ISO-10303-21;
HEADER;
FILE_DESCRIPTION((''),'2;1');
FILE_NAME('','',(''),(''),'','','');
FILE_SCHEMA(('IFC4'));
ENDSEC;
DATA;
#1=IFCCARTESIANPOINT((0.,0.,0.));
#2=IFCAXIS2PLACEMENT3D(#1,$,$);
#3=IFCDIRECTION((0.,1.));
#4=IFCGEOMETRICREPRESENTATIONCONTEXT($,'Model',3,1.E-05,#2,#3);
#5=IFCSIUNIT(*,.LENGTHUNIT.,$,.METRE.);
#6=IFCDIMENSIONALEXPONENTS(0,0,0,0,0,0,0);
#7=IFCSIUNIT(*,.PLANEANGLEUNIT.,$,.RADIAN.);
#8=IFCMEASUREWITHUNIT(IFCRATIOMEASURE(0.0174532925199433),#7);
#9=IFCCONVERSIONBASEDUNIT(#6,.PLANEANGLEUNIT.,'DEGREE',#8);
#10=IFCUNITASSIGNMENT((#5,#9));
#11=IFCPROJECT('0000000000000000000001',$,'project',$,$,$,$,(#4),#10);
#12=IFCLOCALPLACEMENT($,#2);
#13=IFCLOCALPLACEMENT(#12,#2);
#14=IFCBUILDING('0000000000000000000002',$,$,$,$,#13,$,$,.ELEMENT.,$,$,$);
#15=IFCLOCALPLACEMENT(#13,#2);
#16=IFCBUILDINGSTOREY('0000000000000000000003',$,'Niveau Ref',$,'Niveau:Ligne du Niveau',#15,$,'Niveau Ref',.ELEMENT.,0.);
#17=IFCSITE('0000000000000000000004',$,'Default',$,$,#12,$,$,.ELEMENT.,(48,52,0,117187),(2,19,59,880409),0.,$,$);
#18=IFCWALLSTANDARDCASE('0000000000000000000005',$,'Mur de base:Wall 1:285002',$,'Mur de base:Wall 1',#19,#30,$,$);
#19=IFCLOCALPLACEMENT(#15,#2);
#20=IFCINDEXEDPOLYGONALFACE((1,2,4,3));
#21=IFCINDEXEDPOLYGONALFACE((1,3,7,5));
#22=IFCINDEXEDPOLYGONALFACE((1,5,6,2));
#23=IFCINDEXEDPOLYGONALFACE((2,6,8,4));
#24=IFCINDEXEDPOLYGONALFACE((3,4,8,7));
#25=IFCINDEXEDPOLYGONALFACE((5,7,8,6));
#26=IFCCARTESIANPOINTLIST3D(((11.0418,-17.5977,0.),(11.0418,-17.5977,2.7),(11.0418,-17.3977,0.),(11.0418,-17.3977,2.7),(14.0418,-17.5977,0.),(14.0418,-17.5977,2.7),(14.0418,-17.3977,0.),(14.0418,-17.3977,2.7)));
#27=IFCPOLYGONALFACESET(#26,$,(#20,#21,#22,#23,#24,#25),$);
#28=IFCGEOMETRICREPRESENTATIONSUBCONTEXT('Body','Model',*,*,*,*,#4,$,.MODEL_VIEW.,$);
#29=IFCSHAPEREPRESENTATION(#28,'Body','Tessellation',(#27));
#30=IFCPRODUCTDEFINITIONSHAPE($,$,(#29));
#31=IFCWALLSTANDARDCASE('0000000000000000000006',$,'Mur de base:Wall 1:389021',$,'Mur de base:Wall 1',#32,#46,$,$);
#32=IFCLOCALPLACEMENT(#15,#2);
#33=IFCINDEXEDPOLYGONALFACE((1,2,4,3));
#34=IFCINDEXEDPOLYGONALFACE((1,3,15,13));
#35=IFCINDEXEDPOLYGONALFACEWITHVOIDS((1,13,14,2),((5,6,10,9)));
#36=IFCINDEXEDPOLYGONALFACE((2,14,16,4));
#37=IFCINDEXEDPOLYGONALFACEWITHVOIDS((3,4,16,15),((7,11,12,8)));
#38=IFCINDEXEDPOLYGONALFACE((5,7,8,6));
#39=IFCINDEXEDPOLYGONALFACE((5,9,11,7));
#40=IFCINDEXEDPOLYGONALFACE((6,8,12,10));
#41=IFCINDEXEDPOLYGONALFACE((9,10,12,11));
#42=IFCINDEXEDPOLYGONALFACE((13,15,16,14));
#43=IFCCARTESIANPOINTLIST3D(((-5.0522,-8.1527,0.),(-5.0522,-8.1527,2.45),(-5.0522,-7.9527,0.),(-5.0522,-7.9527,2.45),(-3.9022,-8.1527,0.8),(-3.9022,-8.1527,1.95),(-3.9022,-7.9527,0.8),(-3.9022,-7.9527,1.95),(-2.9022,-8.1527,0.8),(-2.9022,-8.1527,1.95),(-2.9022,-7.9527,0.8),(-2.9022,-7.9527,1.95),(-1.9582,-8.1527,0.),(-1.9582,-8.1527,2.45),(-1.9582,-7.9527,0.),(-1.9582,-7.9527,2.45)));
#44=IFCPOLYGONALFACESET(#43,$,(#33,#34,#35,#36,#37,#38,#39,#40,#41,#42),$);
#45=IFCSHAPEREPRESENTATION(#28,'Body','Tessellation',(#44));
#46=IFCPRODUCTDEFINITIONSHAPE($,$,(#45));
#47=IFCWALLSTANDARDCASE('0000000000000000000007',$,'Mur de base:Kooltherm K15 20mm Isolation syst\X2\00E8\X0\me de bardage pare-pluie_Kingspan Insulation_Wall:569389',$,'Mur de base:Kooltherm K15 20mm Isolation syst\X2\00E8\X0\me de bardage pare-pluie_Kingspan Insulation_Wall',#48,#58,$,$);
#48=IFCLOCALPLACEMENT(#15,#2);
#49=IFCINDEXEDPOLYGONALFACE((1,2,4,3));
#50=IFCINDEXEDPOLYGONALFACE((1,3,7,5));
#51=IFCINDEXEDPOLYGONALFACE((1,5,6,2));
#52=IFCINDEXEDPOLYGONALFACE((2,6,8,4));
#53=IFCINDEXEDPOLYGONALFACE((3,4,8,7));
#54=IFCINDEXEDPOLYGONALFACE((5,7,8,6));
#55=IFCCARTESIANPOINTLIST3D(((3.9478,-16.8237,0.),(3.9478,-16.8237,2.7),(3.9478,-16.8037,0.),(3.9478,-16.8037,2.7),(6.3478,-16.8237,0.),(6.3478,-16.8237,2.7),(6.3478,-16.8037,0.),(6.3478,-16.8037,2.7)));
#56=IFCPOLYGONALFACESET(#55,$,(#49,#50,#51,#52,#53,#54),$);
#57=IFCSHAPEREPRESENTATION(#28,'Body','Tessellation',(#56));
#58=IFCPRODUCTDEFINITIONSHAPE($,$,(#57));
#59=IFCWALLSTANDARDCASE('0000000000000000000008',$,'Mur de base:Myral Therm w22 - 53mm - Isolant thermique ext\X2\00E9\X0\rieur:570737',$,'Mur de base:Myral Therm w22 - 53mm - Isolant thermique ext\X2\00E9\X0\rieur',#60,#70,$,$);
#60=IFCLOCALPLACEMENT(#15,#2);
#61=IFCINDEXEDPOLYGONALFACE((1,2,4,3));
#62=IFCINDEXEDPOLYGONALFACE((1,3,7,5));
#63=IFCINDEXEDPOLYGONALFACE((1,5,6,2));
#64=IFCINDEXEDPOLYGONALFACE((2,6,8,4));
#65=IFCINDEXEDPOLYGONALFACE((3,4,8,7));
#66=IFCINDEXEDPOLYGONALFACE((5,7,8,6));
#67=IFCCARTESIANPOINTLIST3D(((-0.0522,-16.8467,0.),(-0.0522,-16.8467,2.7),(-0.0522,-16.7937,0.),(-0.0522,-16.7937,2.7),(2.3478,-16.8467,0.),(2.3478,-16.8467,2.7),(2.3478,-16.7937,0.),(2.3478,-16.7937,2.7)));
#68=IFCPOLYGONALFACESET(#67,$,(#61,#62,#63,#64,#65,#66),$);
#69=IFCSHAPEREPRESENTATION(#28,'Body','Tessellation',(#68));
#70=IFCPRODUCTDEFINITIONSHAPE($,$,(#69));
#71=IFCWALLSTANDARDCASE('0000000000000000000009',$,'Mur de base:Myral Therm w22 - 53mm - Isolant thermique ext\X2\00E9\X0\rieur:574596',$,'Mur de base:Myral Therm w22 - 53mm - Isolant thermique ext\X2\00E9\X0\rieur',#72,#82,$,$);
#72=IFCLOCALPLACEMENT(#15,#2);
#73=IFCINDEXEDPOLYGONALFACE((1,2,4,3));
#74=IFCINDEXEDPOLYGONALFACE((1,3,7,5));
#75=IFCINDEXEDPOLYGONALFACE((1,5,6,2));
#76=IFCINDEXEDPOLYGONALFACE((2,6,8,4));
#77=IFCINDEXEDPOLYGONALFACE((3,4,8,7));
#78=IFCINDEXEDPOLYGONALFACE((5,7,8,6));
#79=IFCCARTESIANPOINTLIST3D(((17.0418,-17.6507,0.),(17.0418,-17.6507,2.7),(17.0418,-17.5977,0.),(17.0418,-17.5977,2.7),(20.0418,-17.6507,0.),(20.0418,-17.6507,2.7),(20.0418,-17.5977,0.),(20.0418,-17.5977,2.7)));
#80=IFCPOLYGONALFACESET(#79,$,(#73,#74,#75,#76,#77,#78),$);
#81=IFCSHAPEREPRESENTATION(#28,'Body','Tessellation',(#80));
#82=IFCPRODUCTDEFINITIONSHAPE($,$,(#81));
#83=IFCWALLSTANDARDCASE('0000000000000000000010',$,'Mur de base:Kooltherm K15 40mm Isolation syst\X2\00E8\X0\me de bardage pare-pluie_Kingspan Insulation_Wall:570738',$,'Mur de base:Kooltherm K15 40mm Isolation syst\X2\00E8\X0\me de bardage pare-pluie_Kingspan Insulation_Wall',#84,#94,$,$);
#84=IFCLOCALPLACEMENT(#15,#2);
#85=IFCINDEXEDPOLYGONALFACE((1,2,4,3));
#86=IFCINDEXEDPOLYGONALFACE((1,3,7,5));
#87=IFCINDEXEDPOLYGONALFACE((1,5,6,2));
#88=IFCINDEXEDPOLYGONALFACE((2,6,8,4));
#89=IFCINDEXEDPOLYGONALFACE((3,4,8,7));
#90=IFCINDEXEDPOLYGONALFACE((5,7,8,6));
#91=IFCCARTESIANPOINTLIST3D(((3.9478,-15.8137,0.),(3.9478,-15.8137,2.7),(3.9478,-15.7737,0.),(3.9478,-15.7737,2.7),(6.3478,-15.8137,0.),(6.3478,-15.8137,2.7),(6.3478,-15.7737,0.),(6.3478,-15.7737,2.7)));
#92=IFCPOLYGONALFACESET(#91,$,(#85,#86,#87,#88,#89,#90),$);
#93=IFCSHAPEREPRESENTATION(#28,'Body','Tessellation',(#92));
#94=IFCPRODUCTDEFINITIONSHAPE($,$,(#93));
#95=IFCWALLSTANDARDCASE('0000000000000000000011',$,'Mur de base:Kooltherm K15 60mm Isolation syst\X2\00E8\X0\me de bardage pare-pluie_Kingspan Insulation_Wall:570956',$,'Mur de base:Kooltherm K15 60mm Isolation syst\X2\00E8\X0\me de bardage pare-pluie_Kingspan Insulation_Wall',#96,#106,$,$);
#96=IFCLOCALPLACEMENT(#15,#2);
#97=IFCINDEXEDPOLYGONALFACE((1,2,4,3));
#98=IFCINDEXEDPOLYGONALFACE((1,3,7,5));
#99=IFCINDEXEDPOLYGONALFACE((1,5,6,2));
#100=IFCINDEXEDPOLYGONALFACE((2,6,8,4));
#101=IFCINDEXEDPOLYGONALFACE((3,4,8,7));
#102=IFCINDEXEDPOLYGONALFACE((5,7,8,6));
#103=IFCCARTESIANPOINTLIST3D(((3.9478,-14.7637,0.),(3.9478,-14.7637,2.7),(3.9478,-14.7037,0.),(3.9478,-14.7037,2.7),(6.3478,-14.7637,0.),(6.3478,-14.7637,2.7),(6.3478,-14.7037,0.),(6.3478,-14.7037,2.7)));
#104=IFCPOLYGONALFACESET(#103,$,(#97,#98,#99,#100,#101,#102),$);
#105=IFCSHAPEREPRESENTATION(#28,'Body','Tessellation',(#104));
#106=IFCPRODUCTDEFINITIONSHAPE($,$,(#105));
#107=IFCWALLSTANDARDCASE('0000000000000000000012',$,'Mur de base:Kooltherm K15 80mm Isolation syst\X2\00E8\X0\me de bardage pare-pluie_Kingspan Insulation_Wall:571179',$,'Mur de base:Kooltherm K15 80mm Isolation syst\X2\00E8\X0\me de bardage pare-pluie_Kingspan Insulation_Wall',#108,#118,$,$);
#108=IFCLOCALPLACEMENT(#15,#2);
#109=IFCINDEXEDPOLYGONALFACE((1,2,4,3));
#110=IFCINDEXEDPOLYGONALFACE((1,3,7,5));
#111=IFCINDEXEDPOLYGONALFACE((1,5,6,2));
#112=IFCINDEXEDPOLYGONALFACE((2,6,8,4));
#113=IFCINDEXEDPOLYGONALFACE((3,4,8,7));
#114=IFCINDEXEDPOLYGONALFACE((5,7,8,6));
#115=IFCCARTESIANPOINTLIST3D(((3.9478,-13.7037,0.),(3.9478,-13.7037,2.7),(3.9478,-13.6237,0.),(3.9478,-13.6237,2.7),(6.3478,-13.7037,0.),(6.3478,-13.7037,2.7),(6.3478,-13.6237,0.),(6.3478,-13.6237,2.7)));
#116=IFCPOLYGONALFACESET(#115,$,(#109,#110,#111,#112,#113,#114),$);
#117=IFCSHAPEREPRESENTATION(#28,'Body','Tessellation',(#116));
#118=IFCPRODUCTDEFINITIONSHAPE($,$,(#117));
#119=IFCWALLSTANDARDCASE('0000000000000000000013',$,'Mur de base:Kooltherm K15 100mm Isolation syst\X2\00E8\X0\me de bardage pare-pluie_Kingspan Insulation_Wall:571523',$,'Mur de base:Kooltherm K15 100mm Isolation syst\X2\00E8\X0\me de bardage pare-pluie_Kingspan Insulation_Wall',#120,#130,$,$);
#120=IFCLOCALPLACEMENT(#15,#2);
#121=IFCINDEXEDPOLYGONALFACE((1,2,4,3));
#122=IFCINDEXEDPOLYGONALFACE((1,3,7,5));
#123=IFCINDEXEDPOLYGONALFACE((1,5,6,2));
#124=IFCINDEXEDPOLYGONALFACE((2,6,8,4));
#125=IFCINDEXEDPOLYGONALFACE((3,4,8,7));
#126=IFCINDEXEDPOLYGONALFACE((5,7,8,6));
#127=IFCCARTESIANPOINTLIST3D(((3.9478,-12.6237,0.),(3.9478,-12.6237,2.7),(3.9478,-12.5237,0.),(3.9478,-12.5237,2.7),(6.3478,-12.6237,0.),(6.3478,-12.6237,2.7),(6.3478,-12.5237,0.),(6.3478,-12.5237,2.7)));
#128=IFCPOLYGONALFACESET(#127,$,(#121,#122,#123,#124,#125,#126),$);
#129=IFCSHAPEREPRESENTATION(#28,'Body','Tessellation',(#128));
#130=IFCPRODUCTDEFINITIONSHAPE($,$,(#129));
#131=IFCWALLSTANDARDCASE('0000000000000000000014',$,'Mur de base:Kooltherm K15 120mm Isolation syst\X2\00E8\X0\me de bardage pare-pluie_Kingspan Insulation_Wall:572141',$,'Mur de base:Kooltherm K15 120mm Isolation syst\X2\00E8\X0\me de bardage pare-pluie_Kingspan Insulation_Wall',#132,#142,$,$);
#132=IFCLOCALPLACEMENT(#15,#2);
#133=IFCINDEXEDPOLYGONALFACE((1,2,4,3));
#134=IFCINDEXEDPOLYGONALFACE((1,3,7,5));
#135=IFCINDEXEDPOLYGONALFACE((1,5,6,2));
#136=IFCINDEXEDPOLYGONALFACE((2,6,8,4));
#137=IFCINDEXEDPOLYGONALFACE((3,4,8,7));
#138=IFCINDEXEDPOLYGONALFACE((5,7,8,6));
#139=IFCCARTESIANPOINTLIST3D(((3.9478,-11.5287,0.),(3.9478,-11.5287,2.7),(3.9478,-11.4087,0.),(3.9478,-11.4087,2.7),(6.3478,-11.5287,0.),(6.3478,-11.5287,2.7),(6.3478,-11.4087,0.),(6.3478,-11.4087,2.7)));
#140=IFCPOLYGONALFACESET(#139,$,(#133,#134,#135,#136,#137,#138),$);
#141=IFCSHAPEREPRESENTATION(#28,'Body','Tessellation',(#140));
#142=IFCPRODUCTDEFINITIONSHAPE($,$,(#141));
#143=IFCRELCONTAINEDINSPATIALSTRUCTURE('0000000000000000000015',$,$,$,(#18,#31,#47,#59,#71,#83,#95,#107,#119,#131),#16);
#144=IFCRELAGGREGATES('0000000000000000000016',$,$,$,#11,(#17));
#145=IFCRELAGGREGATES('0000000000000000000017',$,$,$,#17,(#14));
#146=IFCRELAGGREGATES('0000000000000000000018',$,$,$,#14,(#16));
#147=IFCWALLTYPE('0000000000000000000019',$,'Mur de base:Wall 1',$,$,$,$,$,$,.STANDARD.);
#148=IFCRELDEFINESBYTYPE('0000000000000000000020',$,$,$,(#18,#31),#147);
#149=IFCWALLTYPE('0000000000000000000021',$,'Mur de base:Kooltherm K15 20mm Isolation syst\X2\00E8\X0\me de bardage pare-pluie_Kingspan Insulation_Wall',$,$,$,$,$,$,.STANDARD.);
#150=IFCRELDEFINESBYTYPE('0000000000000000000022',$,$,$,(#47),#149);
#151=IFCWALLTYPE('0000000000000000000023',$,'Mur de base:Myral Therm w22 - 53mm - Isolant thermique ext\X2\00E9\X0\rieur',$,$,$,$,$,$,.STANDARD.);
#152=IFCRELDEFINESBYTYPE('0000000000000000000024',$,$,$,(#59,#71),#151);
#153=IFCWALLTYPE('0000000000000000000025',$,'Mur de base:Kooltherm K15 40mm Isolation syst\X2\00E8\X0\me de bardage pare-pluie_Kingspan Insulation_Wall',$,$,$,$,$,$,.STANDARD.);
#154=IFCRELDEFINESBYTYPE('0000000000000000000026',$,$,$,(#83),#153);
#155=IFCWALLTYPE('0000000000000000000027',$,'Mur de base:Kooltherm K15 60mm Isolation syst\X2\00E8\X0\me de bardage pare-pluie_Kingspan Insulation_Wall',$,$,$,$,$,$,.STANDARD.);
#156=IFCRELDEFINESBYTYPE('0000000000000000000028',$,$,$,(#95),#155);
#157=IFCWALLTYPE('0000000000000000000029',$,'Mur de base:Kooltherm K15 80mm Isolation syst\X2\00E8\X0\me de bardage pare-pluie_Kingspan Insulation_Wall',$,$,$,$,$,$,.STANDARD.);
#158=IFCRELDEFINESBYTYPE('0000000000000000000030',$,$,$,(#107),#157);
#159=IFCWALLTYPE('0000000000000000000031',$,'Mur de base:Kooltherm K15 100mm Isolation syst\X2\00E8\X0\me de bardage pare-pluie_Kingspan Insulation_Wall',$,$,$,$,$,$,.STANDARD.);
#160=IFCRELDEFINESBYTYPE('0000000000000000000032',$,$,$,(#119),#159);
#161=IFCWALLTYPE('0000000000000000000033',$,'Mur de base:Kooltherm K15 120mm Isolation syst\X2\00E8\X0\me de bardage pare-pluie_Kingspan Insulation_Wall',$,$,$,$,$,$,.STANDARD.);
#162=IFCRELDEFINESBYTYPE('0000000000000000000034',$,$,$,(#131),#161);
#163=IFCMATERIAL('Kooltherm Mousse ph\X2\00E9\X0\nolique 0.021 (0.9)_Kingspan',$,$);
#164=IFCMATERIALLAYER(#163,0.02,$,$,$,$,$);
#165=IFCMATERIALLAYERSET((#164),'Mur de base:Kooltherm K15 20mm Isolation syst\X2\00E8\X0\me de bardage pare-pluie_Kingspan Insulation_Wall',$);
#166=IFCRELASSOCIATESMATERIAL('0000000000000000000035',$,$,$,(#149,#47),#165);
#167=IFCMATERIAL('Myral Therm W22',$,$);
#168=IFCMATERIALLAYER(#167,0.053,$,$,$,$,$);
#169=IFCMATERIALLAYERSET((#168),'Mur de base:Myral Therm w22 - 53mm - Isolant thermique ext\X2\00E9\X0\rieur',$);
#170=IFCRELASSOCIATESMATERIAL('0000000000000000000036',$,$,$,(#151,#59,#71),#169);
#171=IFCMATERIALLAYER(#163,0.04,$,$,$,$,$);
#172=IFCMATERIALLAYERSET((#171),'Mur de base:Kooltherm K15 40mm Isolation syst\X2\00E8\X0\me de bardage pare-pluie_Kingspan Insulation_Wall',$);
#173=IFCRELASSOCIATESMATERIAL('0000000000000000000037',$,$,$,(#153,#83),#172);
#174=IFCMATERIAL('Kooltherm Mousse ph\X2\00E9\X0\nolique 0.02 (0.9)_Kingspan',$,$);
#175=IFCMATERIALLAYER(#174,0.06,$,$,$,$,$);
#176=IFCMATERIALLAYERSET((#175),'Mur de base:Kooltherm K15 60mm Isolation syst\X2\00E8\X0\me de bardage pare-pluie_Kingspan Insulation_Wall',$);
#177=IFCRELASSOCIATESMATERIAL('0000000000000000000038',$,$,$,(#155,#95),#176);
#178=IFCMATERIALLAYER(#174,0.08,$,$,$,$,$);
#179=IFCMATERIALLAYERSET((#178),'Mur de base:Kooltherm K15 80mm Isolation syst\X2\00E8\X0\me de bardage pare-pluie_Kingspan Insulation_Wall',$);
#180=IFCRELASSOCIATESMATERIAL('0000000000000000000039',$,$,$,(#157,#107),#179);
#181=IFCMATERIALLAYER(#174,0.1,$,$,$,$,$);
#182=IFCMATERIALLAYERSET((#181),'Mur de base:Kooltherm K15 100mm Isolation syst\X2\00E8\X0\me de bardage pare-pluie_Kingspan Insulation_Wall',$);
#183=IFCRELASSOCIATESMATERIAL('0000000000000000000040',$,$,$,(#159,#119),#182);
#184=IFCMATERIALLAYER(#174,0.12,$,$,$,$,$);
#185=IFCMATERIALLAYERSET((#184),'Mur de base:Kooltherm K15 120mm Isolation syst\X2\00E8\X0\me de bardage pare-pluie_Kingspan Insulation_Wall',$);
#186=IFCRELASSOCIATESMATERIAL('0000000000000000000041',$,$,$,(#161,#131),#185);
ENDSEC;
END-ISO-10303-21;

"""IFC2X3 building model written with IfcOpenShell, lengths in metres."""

from ifc_helpers import new_model, entity, si_unit, converted_unit, direction, frame, frame_2d, origin, place, context, subcontext, project, spatial, rectangle, extrude, material, layer, layer_set, layer_usage, type_object, element, save


model = new_model("IFC2X3")

# Units and contexts
model_context = context("Model", 3, precision=1e-05, world=origin(), true_north=direction((0.0, 1.0)))
body_context = subcontext(model_context, "Body", "Model", "MODEL_VIEW")
ifc_project = project(units=[si_unit("LENGTHUNIT", "METRE"), converted_unit("PLANEANGLEUNIT", "DEGREE", entity("IfcRatioMeasure", 0.0174532925199433), si_unit("PLANEANGLEUNIT", "RADIAN"), dimensions=[0, 0, 0, 0, 0, 0, 0])], contexts=[model_context])

# Site, building, storey
site_placement = place(None, origin())
site = spatial("IfcSite", under=ifc_project, at=site_placement, Name="Default", CompositionType="ELEMENT", RefLatitude=(48, 52, 0, 117187), RefLongitude=(2, 19, 59, 880409), RefElevation=0.0)
building_placement = place(site_placement, origin())
building = spatial("IfcBuilding", under=site, at=building_placement, CompositionType="ELEMENT")
storey_placement = place(building_placement, origin())
storey = spatial("IfcBuildingStorey", under=building, at=storey_placement, Name="Niveau Ref", ObjectType="Niveau:Ligne du Niveau", LongName="Niveau Ref", CompositionType="ELEMENT", Elevation=0.0)

# Wall
wall_type_1 = type_object("IfcWallType", Name="Mur de base:Wall 1", PredefinedType="STANDARD")
for number, where, name in (
    (1, (11.0418, -17.4977, 0.0), "Mur de base:Wall 1:285002"),
):
    element("IfcWallStandardCase", number, at=place(storey_placement, frame(where)), inside=storey, type_object=wall_type_1, Name=name, ObjectType="Mur de base:Wall 1", context=body_context, shape_type="SweptSolid", body=[
        extrude(rectangle(XDim=3.0, YDim=0.2, at=frame_2d((1.5, 0.0), x_axis=(-1.0, 0.0))), origin(), (0.0, 0.0, 1.0), 2.7),
    ])

# Wall, opening
wall_1_placement = place(storey_placement, frame((-1.9582, -8.0527, 0.0), z_axis=(0.0, 0.0, 1.0), x_axis=(-1.0, 0.0, 0.0)))
wall_1 = element("IfcWallStandardCase", 2, at=wall_1_placement, inside=storey, type_object=wall_type_1, Name="Mur de base:Wall 1:389021", ObjectType="Mur de base:Wall 1", context=body_context, shape_type="SweptSolid", body=[
    extrude(rectangle(XDim=3.094, YDim=0.2, at=frame_2d((1.547, 0.0), x_axis=(-1.0, 0.0))), origin(), (0.0, 0.0, 1.0), 2.45),
])
opening_placement = place(wall_1_placement, frame((0.944, -0.1, 0.8)))
element("IfcOpeningElement", 3, at=opening_placement, cuts=wall_1, ObjectType="Opening", context=body_context, shape_type="SweptSolid", body=[
    extrude(rectangle(XDim=1.15, YDim=1.0, at=frame_2d((0.575, 0.5), x_axis=(1.0, 0.0))), frame((0.0, 0.0, 0.0), z_axis=(0.0, 1.0, 0.0), x_axis=(0.0, 0.0, 1.0)), (0.0, 0.0, 1.0), 0.2),
])

# Walls
ifc_material_1 = material(Name="Kooltherm Mousse phénolique 0.021 (0.9)_Kingspan")
ifc_layer_1 = layer(ifc_material_1, 0.02)
ifc_layer_set_1 = layer_set([ifc_layer_1], Name="Mur de base:Kooltherm K15 20mm Isolation système de bardage pare-pluie_Kingspan Insulation_Wall")
ifc_layer_usage_1 = layer_usage(ifc_layer_set_1, "AXIS2", "NEGATIVE", 0.01)
wall_type_2 = type_object("IfcWallType", Name="Mur de base:Kooltherm K15 20mm Isolation système de bardage pare-pluie_Kingspan Insulation_Wall", PredefinedType="STANDARD", material=ifc_layer_set_1)
wall_2_placement = place(storey_placement, frame((3.9478, -16.8137, 0.0)))
element("IfcWallStandardCase", 4, at=wall_2_placement, inside=storey, type_object=wall_type_2, material=ifc_layer_usage_1, Name="Mur de base:Kooltherm K15 20mm Isolation système de bardage pare-pluie_Kingspan Insulation_Wall:569389", ObjectType="Mur de base:Kooltherm K15 20mm Isolation système de bardage pare-pluie_Kingspan Insulation_Wall", context=body_context, shape_type="SweptSolid", body=[
    extrude(rectangle(XDim=2.4, YDim=0.02, at=frame_2d((1.2, 0.0), x_axis=(-1.0, 0.0))), origin(), (0.0, 0.0, 1.0), 2.7),
])
ifc_material_2 = material(Name="Myral Therm W22")
ifc_layer_2 = layer(ifc_material_2, 0.053)
ifc_layer_set_2 = layer_set([ifc_layer_2], Name="Mur de base:Myral Therm w22 - 53mm - Isolant thermique extérieur")
ifc_layer_usage_2 = layer_usage(ifc_layer_set_2, "AXIS2", "NEGATIVE", 0.0265)
wall_type_3 = type_object("IfcWallType", Name="Mur de base:Myral Therm w22 - 53mm - Isolant thermique extérieur", PredefinedType="STANDARD", material=ifc_layer_set_2)
wall_3_placement = place(storey_placement, frame((-0.0522, -16.8202, 0.0)))
element("IfcWallStandardCase", 5, at=wall_3_placement, inside=storey, type_object=wall_type_3, material=ifc_layer_usage_2, Name="Mur de base:Myral Therm w22 - 53mm - Isolant thermique extérieur:570737", ObjectType="Mur de base:Myral Therm w22 - 53mm - Isolant thermique extérieur", context=body_context, shape_type="SweptSolid", body=[
    extrude(rectangle(XDim=2.4, YDim=0.053, at=frame_2d((1.2, 0.0), x_axis=(-1.0, 0.0))), origin(), (0.0, 0.0, 1.0), 2.7),
])
ifc_layer_usage_3 = layer_usage(ifc_layer_set_2, "AXIS2", "NEGATIVE", 0.0265)
wall_4_placement = place(storey_placement, frame((17.0418, -17.6242, 0.0)))
element("IfcWallStandardCase", 6, at=wall_4_placement, inside=storey, type_object=wall_type_3, material=ifc_layer_usage_3, Name="Mur de base:Myral Therm w22 - 53mm - Isolant thermique extérieur:574596", ObjectType="Mur de base:Myral Therm w22 - 53mm - Isolant thermique extérieur", context=body_context, shape_type="SweptSolid", body=[
    extrude(rectangle(XDim=3.0, YDim=0.053, at=frame_2d((1.5, 0.0), x_axis=(-1.0, 0.0))), origin(), (0.0, 0.0, 1.0), 2.7),
])
ifc_layer_3 = layer(ifc_material_1, 0.04)
ifc_layer_set_3 = layer_set([ifc_layer_3], Name="Mur de base:Kooltherm K15 40mm Isolation système de bardage pare-pluie_Kingspan Insulation_Wall")
ifc_layer_usage_4 = layer_usage(ifc_layer_set_3, "AXIS2", "NEGATIVE", 0.02)
wall_type_4 = type_object("IfcWallType", Name="Mur de base:Kooltherm K15 40mm Isolation système de bardage pare-pluie_Kingspan Insulation_Wall", PredefinedType="STANDARD", material=ifc_layer_set_3)
wall_5_placement = place(storey_placement, frame((3.9478, -15.7937, 0.0)))
element("IfcWallStandardCase", 7, at=wall_5_placement, inside=storey, type_object=wall_type_4, material=ifc_layer_usage_4, Name="Mur de base:Kooltherm K15 40mm Isolation système de bardage pare-pluie_Kingspan Insulation_Wall:570738", ObjectType="Mur de base:Kooltherm K15 40mm Isolation système de bardage pare-pluie_Kingspan Insulation_Wall", context=body_context, shape_type="SweptSolid", body=[
    extrude(rectangle(XDim=2.4, YDim=0.04, at=frame_2d((1.2, 0.0), x_axis=(-1.0, 0.0))), origin(), (0.0, 0.0, 1.0), 2.7),
])
ifc_material_3 = material(Name="Kooltherm Mousse phénolique 0.02 (0.9)_Kingspan")
ifc_layer_4 = layer(ifc_material_3, 0.06)
ifc_layer_set_4 = layer_set([ifc_layer_4], Name="Mur de base:Kooltherm K15 60mm Isolation système de bardage pare-pluie_Kingspan Insulation_Wall")
ifc_layer_usage_5 = layer_usage(ifc_layer_set_4, "AXIS2", "NEGATIVE", 0.03)
wall_type_5 = type_object("IfcWallType", Name="Mur de base:Kooltherm K15 60mm Isolation système de bardage pare-pluie_Kingspan Insulation_Wall", PredefinedType="STANDARD", material=ifc_layer_set_4)
wall_6_placement = place(storey_placement, frame((3.9478, -14.7337, 0.0)))
element("IfcWallStandardCase", 8, at=wall_6_placement, inside=storey, type_object=wall_type_5, material=ifc_layer_usage_5, Name="Mur de base:Kooltherm K15 60mm Isolation système de bardage pare-pluie_Kingspan Insulation_Wall:570956", ObjectType="Mur de base:Kooltherm K15 60mm Isolation système de bardage pare-pluie_Kingspan Insulation_Wall", context=body_context, shape_type="SweptSolid", body=[
    extrude(rectangle(XDim=2.4, YDim=0.06, at=frame_2d((1.2, 0.0), x_axis=(-1.0, 0.0))), origin(), (0.0, 0.0, 1.0), 2.7),
])
ifc_layer_5 = layer(ifc_material_3, 0.08)
ifc_layer_set_5 = layer_set([ifc_layer_5], Name="Mur de base:Kooltherm K15 80mm Isolation système de bardage pare-pluie_Kingspan Insulation_Wall")
ifc_layer_usage_6 = layer_usage(ifc_layer_set_5, "AXIS2", "NEGATIVE", 0.04)
wall_type_6 = type_object("IfcWallType", Name="Mur de base:Kooltherm K15 80mm Isolation système de bardage pare-pluie_Kingspan Insulation_Wall", PredefinedType="STANDARD", material=ifc_layer_set_5)
wall_7_placement = place(storey_placement, frame((3.9478, -13.6637, 0.0)))
element("IfcWallStandardCase", 9, at=wall_7_placement, inside=storey, type_object=wall_type_6, material=ifc_layer_usage_6, Name="Mur de base:Kooltherm K15 80mm Isolation système de bardage pare-pluie_Kingspan Insulation_Wall:571179", ObjectType="Mur de base:Kooltherm K15 80mm Isolation système de bardage pare-pluie_Kingspan Insulation_Wall", context=body_context, shape_type="SweptSolid", body=[
    extrude(rectangle(XDim=2.4, YDim=0.08, at=frame_2d((1.2, 0.0), x_axis=(-1.0, 0.0))), origin(), (0.0, 0.0, 1.0), 2.7),
])
ifc_layer_6 = layer(ifc_material_3, 0.1)
ifc_layer_set_6 = layer_set([ifc_layer_6], Name="Mur de base:Kooltherm K15 100mm Isolation système de bardage pare-pluie_Kingspan Insulation_Wall")
ifc_layer_usage_7 = layer_usage(ifc_layer_set_6, "AXIS2", "NEGATIVE", 0.05)
wall_type_7 = type_object("IfcWallType", Name="Mur de base:Kooltherm K15 100mm Isolation système de bardage pare-pluie_Kingspan Insulation_Wall", PredefinedType="STANDARD", material=ifc_layer_set_6)
wall_8_placement = place(storey_placement, frame((3.9478, -12.5737, 0.0)))
element("IfcWallStandardCase", 10, at=wall_8_placement, inside=storey, type_object=wall_type_7, material=ifc_layer_usage_7, Name="Mur de base:Kooltherm K15 100mm Isolation système de bardage pare-pluie_Kingspan Insulation_Wall:571523", ObjectType="Mur de base:Kooltherm K15 100mm Isolation système de bardage pare-pluie_Kingspan Insulation_Wall", context=body_context, shape_type="SweptSolid", body=[
    extrude(rectangle(XDim=2.4, YDim=0.1, at=frame_2d((1.2, 0.0), x_axis=(-1.0, 0.0))), origin(), (0.0, 0.0, 1.0), 2.7),
])
ifc_layer_7 = layer(ifc_material_3, 0.12)
ifc_layer_set_7 = layer_set([ifc_layer_7], Name="Mur de base:Kooltherm K15 120mm Isolation système de bardage pare-pluie_Kingspan Insulation_Wall")
ifc_layer_usage_8 = layer_usage(ifc_layer_set_7, "AXIS2", "NEGATIVE", 0.06)
wall_type_8 = type_object("IfcWallType", Name="Mur de base:Kooltherm K15 120mm Isolation système de bardage pare-pluie_Kingspan Insulation_Wall", PredefinedType="STANDARD", material=ifc_layer_set_7)
wall_9_placement = place(storey_placement, frame((3.9478, -11.4687, 0.0)))
element("IfcWallStandardCase", 11, at=wall_9_placement, inside=storey, type_object=wall_type_8, material=ifc_layer_usage_8, Name="Mur de base:Kooltherm K15 120mm Isolation système de bardage pare-pluie_Kingspan Insulation_Wall:572141", ObjectType="Mur de base:Kooltherm K15 120mm Isolation système de bardage pare-pluie_Kingspan Insulation_Wall", context=body_context, shape_type="SweptSolid", body=[
    extrude(rectangle(XDim=2.4, YDim=0.12, at=frame_2d((1.2, 0.0), x_axis=(-1.0, 0.0))), origin(), (0.0, 0.0, 1.0), 2.7),
])

save(model, "model.ifc")
